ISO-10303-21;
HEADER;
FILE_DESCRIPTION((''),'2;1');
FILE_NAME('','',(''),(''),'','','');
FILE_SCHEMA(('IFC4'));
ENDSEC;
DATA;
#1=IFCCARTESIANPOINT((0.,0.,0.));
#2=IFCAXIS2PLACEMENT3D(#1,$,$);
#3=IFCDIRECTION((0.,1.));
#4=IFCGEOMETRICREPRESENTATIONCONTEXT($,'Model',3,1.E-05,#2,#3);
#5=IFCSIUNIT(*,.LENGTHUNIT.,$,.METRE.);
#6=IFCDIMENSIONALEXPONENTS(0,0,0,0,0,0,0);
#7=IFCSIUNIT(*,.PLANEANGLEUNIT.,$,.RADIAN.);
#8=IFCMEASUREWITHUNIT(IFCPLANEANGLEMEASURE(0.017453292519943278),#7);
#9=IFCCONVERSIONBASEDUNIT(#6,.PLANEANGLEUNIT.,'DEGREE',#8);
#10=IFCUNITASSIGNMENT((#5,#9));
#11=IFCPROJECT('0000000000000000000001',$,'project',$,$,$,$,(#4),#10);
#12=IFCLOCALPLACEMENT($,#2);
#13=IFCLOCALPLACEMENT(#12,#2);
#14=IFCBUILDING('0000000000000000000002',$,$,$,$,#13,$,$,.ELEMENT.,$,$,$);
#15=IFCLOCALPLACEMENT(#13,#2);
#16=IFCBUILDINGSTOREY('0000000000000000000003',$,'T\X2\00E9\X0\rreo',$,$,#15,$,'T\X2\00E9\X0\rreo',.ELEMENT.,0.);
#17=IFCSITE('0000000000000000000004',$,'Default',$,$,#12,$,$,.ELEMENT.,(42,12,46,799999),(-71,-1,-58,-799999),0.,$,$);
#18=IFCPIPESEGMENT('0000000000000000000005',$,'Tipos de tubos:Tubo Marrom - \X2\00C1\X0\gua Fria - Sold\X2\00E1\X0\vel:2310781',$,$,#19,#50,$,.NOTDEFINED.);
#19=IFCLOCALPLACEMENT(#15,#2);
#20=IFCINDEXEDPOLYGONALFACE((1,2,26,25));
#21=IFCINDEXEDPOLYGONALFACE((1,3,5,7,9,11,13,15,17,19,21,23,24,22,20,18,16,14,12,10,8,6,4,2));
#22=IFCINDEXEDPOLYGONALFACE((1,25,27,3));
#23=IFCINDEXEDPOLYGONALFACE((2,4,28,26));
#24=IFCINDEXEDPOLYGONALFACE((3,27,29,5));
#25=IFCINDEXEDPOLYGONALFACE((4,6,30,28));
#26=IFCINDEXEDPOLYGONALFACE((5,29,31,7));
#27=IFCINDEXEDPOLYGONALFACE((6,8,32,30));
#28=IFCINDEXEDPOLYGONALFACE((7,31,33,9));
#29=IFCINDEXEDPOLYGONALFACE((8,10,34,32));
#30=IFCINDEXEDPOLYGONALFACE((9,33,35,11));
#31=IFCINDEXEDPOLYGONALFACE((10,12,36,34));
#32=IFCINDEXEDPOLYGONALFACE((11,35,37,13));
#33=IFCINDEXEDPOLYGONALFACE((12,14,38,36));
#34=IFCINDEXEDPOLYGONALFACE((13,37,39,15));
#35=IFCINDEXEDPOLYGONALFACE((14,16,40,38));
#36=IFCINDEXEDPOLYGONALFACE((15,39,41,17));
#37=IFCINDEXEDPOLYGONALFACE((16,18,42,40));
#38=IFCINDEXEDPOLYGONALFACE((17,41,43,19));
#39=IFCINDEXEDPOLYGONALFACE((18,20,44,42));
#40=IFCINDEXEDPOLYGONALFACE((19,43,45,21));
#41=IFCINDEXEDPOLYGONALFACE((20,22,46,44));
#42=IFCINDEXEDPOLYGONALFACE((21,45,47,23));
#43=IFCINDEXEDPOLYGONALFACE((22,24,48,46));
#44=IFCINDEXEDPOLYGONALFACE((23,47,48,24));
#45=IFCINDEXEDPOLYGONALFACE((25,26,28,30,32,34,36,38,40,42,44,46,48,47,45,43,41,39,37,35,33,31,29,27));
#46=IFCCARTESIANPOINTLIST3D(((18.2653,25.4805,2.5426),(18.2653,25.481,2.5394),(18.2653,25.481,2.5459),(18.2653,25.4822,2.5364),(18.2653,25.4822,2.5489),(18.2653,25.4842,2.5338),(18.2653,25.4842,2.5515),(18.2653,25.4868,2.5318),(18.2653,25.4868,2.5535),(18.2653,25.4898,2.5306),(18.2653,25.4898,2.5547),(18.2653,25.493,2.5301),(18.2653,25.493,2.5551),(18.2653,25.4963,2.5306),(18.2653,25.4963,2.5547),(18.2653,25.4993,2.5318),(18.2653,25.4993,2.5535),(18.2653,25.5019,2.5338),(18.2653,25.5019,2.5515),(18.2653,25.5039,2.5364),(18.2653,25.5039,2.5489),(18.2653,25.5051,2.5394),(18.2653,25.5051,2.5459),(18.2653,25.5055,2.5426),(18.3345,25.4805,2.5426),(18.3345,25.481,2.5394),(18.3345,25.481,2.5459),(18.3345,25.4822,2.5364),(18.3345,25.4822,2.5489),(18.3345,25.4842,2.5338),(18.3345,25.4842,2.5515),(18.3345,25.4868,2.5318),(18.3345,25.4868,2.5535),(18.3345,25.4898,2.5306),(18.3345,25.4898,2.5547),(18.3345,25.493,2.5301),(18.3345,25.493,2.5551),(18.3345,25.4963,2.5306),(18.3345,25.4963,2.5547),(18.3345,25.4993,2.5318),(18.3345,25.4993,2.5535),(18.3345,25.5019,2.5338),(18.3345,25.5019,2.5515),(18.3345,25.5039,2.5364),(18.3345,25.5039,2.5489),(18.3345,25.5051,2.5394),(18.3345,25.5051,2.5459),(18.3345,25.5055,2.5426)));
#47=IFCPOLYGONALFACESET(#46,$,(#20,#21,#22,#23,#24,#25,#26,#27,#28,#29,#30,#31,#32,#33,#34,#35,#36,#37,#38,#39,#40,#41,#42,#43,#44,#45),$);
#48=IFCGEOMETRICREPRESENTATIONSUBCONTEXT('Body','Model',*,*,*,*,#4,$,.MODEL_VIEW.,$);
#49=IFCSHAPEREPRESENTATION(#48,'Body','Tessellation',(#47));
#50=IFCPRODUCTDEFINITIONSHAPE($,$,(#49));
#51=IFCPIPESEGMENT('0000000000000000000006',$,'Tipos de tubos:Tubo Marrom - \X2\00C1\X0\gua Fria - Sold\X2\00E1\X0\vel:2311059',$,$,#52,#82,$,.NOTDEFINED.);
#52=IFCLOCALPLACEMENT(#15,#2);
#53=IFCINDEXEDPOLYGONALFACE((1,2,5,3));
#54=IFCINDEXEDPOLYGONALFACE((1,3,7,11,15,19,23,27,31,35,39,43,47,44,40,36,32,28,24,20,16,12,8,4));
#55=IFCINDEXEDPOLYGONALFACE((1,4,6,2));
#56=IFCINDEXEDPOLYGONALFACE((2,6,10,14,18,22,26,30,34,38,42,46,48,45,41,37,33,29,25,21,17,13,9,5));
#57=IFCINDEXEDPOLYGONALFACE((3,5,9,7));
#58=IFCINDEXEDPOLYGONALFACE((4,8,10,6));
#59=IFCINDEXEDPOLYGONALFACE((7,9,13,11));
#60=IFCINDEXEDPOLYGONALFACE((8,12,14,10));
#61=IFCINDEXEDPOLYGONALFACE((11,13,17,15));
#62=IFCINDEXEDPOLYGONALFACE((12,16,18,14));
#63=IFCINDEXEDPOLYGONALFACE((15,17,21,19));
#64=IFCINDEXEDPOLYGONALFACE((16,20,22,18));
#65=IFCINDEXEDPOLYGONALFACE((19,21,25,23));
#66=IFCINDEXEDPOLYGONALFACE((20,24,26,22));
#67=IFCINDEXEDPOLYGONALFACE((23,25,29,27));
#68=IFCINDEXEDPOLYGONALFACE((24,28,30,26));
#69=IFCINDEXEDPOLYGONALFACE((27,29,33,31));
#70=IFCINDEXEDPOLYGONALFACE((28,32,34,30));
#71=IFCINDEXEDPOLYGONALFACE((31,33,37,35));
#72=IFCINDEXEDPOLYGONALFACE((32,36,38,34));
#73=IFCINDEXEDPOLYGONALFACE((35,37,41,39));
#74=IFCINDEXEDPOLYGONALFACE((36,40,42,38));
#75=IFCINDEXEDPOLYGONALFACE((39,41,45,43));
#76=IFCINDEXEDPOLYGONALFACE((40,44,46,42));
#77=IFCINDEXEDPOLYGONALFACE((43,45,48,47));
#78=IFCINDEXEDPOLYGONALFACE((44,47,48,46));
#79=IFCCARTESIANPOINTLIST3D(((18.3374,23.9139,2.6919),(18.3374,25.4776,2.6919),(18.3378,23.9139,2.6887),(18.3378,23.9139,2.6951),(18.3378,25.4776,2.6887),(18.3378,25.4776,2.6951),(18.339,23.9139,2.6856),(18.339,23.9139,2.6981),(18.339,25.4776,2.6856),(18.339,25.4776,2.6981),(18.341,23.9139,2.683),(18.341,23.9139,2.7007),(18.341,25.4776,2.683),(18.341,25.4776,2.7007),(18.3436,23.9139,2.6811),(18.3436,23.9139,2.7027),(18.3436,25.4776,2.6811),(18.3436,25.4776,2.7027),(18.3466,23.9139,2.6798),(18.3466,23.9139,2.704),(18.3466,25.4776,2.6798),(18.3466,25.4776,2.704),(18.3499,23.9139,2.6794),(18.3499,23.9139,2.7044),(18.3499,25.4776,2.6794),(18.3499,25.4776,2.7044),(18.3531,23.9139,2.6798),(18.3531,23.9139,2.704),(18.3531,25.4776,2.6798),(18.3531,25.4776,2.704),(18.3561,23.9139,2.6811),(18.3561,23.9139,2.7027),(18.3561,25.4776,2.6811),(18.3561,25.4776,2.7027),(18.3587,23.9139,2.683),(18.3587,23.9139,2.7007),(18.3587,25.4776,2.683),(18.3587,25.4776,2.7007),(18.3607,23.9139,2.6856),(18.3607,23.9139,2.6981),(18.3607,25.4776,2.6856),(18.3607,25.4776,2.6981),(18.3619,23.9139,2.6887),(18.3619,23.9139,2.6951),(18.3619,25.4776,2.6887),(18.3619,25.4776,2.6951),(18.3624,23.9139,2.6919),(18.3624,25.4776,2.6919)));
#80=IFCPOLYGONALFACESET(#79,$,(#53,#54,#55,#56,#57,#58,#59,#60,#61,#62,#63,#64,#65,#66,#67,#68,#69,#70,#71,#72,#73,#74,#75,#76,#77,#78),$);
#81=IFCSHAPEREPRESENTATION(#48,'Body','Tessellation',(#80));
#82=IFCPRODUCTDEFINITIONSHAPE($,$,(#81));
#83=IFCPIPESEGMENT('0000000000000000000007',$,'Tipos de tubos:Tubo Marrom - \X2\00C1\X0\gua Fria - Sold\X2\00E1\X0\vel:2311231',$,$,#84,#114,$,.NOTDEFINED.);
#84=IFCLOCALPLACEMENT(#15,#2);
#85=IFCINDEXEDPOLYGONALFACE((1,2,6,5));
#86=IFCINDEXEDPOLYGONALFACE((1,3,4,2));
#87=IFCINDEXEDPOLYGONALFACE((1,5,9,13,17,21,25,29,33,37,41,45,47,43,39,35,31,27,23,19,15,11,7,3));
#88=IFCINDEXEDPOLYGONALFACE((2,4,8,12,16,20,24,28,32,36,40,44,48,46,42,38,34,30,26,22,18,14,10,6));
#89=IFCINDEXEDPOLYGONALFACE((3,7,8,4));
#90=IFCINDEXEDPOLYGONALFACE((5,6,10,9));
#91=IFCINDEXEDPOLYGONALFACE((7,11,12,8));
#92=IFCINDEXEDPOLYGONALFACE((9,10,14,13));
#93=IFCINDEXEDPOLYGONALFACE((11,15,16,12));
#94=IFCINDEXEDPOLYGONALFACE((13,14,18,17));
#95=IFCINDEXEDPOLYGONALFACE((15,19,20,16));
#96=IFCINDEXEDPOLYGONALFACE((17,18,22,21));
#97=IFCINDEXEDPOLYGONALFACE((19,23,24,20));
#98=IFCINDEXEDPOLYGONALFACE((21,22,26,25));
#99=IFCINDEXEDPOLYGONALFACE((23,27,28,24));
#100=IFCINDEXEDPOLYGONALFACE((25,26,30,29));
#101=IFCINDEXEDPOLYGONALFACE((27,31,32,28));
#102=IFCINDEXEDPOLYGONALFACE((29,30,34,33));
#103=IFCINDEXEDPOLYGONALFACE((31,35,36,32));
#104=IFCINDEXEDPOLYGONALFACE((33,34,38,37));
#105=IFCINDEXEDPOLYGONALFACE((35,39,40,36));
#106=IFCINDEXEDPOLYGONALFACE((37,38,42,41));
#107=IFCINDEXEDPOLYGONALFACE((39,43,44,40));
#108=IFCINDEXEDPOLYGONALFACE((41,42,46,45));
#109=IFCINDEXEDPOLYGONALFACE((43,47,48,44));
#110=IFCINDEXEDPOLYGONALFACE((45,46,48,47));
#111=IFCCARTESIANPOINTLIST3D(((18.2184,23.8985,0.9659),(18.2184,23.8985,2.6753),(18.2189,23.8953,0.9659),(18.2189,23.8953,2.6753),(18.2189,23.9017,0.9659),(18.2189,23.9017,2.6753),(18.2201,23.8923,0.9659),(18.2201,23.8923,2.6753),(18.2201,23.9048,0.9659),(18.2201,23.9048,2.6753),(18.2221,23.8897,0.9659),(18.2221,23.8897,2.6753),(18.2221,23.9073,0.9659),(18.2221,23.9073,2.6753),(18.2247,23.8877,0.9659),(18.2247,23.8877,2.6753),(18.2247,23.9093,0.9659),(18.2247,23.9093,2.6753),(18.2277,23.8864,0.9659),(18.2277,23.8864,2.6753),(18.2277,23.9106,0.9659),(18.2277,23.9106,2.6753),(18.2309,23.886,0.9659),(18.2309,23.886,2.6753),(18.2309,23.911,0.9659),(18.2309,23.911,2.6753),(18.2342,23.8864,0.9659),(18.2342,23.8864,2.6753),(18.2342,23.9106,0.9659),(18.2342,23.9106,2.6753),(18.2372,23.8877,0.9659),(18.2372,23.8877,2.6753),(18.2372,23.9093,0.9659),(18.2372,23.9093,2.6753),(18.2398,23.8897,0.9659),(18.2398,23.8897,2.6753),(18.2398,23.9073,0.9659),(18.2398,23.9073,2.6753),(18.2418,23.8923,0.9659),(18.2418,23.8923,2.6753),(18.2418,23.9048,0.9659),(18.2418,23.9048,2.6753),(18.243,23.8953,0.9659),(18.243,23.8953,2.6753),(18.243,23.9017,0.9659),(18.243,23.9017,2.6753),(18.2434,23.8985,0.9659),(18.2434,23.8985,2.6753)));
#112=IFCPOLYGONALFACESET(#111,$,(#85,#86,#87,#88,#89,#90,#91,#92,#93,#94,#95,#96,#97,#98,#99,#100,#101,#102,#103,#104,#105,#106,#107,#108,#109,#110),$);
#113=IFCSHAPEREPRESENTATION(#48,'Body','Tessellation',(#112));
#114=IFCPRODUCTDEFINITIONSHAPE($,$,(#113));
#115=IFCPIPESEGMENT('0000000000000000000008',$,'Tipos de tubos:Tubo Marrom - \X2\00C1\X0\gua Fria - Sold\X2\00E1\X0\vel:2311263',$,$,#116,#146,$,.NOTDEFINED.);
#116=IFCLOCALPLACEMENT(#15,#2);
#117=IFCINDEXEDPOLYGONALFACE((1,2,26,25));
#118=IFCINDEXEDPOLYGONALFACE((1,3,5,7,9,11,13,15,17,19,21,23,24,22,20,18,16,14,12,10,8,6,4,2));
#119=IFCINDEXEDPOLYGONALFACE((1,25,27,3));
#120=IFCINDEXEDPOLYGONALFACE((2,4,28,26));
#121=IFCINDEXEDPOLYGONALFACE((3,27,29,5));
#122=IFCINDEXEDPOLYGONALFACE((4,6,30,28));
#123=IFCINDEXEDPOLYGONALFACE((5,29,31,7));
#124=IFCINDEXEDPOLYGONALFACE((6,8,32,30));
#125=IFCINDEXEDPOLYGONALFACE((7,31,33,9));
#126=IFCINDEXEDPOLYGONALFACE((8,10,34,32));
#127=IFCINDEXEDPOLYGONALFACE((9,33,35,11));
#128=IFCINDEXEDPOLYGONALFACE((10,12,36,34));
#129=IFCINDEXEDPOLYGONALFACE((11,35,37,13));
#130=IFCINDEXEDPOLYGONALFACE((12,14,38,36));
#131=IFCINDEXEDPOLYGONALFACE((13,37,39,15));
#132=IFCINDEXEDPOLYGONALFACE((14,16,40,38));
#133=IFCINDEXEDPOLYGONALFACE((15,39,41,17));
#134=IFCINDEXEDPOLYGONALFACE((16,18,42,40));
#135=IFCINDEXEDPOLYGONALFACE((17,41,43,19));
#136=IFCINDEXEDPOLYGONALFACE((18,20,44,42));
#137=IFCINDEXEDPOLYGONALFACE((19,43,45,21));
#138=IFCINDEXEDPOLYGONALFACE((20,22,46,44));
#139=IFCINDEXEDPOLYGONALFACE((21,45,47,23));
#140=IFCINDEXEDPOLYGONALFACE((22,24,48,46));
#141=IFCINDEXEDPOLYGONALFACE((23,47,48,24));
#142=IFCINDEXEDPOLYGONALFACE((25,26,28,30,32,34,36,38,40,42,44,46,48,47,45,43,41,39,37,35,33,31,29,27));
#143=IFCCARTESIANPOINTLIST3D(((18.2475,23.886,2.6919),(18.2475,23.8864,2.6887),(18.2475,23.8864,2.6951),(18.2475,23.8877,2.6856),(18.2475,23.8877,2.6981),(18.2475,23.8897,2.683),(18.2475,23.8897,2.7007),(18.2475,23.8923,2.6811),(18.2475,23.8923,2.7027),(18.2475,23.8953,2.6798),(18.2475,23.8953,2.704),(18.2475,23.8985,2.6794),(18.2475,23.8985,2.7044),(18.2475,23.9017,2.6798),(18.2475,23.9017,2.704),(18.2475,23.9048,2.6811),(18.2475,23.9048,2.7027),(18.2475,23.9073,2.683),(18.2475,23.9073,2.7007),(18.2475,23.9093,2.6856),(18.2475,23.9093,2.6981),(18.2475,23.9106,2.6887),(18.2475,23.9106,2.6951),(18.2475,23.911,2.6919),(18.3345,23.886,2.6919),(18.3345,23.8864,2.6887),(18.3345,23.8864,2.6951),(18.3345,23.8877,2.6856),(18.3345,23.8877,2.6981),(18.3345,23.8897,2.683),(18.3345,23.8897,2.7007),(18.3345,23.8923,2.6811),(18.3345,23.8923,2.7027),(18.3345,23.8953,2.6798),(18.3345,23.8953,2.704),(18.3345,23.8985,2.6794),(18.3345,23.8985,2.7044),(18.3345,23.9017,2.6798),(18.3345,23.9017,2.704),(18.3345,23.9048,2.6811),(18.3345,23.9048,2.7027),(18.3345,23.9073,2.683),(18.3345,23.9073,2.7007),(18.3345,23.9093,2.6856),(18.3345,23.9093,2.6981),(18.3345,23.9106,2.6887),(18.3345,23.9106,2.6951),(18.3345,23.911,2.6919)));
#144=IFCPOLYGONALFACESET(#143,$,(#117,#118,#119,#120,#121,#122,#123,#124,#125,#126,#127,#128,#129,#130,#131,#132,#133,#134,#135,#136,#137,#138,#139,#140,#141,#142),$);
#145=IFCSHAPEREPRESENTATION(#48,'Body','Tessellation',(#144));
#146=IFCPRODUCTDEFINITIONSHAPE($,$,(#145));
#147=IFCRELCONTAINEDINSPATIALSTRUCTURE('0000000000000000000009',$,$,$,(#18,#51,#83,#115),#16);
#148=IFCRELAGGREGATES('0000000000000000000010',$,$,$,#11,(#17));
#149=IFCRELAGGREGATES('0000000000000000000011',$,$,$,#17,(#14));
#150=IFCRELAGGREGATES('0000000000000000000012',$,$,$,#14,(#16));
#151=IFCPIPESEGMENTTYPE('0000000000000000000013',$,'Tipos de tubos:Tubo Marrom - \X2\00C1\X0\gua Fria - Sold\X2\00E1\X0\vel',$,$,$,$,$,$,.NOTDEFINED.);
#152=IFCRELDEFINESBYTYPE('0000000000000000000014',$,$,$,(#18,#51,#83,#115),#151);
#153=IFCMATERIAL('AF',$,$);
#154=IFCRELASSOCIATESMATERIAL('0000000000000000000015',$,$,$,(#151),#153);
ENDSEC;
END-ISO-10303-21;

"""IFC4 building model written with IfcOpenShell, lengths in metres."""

from ifc_helpers import new_model, entity, si_unit, converted_unit, direction, frame, origin, place, context, subcontext, project, spatial, arc, indexed_curve, outline, extrude, material, type_object, element, save


model = new_model("IFC4")

# Units and contexts
model_context = context("Model", 3, precision=1e-05, world=origin(), true_north=direction((0.0, 1.0)))
body_context = subcontext(model_context, "Body", "Model", "MODEL_VIEW")
ifc_project = project(units=[si_unit("LENGTHUNIT", "METRE"), converted_unit("PLANEANGLEUNIT", "DEGREE", entity("IfcPlaneAngleMeasure", 0.017453292519943278), si_unit("PLANEANGLEUNIT", "RADIAN"), dimensions=[0, 0, 0, 0, 0, 0, 0])], contexts=[model_context])

# Site, building, storey
site_placement = place(None, origin())
site = spatial("IfcSite", under=ifc_project, at=site_placement, Name="Default", CompositionType="ELEMENT", RefLatitude=(42, 12, 46, 799999), RefLongitude=(-71, -1, -58, -799999), RefElevation=0.0)
building_placement = place(site_placement, origin())
building = spatial("IfcBuilding", under=site, at=building_placement, CompositionType="ELEMENT")
storey_placement = place(building_placement, origin())
storey = spatial("IfcBuildingStorey", under=building, at=storey_placement, Name="Térreo", LongName="Térreo", CompositionType="ELEMENT", Elevation=0.0)

# Pipe segments
ifc_material_1 = material(Name="AF")
pipe_segment_type_1 = type_object("IfcPipeSegmentType", Name="Tipos de tubos:Tubo Marrom - Água Fria - Soldável", PredefinedType="NOTDEFINED", material=ifc_material_1)
pipe_segment_1_placement = place(storey_placement, origin())
element("IfcPipeSegment", 1, at=pipe_segment_1_placement, inside=storey, type_object=pipe_segment_type_1, Name="Tipos de tubos:Tubo Marrom - Água Fria - Soldável:2310781", PredefinedType="NOTDEFINED", context=body_context, shape_type="SweptSolid", body=[
    extrude(outline(indexed_curve([(0.0125, 0.0), (0.0088, 0.0088), (0.0, 0.0125), (-0.0088, 0.0088), (-0.0125, 0.0), (-0.0088, -0.0088), (0.0, -0.0125), (0.0088, -0.0088)], segments=[arc(1, 2, 3), arc(3, 4, 5), arc(5, 6, 7), arc(7, 8, 1)], self_intersect=False)), frame((18.2653, 25.493, 2.5426), z_axis=(1.0, 0.0, 0.0), x_axis=(0.0, -1.0, 0.0)), (0.0, 0.0, 1.0), 0.0692),
])
pipe_segment_2_placement = place(storey_placement, origin())
element("IfcPipeSegment", 2, at=pipe_segment_2_placement, inside=storey, type_object=pipe_segment_type_1, Name="Tipos de tubos:Tubo Marrom - Água Fria - Soldável:2311059", PredefinedType="NOTDEFINED", context=body_context, shape_type="SweptSolid", body=[
    extrude(outline(indexed_curve([(0.0125, 0.0), (0.0088, 0.0088), (0.0, 0.0125), (-0.0088, 0.0088), (-0.0125, 0.0), (-0.0088, -0.0088), (0.0, -0.0125), (0.0088, -0.0088)], segments=[arc(1, 2, 3), arc(3, 4, 5), arc(5, 6, 7), arc(7, 8, 1)], self_intersect=False)), frame((18.3499, 23.9139, 2.6919), z_axis=(0.0, 1.0, 0.0), x_axis=(1.0, 0.0, 0.0)), (0.0, 0.0, 1.0), 1.5637),
])
pipe_segment_3_placement = place(storey_placement, origin())
element("IfcPipeSegment", 3, at=pipe_segment_3_placement, inside=storey, type_object=pipe_segment_type_1, Name="Tipos de tubos:Tubo Marrom - Água Fria - Soldável:2311231", PredefinedType="NOTDEFINED", context=body_context, shape_type="SweptSolid", body=[
    extrude(outline(indexed_curve([(0.0125, 0.0), (0.0088, 0.0088), (0.0, 0.0125), (-0.0088, 0.0088), (-0.0125, 0.0), (-0.0088, -0.0088), (0.0, -0.0125), (0.0088, -0.0088)], segments=[arc(1, 2, 3), arc(3, 4, 5), arc(5, 6, 7), arc(7, 8, 1)], self_intersect=False)), frame((18.2309, 23.8985, 0.9659), z_axis=(0.000002, 0.0, 1.0), x_axis=(-1.0, 0.0, 0.000002)), (0.0, 0.0, 1.0), 1.7094),
])
pipe_segment_4_placement = place(storey_placement, origin())
element("IfcPipeSegment", 4, at=pipe_segment_4_placement, inside=storey, type_object=pipe_segment_type_1, Name="Tipos de tubos:Tubo Marrom - Água Fria - Soldável:2311263", PredefinedType="NOTDEFINED", context=body_context, shape_type="SweptSolid", body=[
    extrude(outline(indexed_curve([(0.0125, 0.0), (0.0088, 0.0088), (0.0, 0.0125), (-0.0088, 0.0088), (-0.0125, 0.0), (-0.0088, -0.0088), (0.0, -0.0125), (0.0088, -0.0088)], segments=[arc(1, 2, 3), arc(3, 4, 5), arc(5, 6, 7), arc(7, 8, 1)], self_intersect=False)), frame((18.2475, 23.8985, 2.6919), z_axis=(1.0, 0.0, 0.0), x_axis=(0.0, 1.0, 0.0)), (0.0, 0.0, 1.0), 0.0869),
])

save(model, "model.ifc")
